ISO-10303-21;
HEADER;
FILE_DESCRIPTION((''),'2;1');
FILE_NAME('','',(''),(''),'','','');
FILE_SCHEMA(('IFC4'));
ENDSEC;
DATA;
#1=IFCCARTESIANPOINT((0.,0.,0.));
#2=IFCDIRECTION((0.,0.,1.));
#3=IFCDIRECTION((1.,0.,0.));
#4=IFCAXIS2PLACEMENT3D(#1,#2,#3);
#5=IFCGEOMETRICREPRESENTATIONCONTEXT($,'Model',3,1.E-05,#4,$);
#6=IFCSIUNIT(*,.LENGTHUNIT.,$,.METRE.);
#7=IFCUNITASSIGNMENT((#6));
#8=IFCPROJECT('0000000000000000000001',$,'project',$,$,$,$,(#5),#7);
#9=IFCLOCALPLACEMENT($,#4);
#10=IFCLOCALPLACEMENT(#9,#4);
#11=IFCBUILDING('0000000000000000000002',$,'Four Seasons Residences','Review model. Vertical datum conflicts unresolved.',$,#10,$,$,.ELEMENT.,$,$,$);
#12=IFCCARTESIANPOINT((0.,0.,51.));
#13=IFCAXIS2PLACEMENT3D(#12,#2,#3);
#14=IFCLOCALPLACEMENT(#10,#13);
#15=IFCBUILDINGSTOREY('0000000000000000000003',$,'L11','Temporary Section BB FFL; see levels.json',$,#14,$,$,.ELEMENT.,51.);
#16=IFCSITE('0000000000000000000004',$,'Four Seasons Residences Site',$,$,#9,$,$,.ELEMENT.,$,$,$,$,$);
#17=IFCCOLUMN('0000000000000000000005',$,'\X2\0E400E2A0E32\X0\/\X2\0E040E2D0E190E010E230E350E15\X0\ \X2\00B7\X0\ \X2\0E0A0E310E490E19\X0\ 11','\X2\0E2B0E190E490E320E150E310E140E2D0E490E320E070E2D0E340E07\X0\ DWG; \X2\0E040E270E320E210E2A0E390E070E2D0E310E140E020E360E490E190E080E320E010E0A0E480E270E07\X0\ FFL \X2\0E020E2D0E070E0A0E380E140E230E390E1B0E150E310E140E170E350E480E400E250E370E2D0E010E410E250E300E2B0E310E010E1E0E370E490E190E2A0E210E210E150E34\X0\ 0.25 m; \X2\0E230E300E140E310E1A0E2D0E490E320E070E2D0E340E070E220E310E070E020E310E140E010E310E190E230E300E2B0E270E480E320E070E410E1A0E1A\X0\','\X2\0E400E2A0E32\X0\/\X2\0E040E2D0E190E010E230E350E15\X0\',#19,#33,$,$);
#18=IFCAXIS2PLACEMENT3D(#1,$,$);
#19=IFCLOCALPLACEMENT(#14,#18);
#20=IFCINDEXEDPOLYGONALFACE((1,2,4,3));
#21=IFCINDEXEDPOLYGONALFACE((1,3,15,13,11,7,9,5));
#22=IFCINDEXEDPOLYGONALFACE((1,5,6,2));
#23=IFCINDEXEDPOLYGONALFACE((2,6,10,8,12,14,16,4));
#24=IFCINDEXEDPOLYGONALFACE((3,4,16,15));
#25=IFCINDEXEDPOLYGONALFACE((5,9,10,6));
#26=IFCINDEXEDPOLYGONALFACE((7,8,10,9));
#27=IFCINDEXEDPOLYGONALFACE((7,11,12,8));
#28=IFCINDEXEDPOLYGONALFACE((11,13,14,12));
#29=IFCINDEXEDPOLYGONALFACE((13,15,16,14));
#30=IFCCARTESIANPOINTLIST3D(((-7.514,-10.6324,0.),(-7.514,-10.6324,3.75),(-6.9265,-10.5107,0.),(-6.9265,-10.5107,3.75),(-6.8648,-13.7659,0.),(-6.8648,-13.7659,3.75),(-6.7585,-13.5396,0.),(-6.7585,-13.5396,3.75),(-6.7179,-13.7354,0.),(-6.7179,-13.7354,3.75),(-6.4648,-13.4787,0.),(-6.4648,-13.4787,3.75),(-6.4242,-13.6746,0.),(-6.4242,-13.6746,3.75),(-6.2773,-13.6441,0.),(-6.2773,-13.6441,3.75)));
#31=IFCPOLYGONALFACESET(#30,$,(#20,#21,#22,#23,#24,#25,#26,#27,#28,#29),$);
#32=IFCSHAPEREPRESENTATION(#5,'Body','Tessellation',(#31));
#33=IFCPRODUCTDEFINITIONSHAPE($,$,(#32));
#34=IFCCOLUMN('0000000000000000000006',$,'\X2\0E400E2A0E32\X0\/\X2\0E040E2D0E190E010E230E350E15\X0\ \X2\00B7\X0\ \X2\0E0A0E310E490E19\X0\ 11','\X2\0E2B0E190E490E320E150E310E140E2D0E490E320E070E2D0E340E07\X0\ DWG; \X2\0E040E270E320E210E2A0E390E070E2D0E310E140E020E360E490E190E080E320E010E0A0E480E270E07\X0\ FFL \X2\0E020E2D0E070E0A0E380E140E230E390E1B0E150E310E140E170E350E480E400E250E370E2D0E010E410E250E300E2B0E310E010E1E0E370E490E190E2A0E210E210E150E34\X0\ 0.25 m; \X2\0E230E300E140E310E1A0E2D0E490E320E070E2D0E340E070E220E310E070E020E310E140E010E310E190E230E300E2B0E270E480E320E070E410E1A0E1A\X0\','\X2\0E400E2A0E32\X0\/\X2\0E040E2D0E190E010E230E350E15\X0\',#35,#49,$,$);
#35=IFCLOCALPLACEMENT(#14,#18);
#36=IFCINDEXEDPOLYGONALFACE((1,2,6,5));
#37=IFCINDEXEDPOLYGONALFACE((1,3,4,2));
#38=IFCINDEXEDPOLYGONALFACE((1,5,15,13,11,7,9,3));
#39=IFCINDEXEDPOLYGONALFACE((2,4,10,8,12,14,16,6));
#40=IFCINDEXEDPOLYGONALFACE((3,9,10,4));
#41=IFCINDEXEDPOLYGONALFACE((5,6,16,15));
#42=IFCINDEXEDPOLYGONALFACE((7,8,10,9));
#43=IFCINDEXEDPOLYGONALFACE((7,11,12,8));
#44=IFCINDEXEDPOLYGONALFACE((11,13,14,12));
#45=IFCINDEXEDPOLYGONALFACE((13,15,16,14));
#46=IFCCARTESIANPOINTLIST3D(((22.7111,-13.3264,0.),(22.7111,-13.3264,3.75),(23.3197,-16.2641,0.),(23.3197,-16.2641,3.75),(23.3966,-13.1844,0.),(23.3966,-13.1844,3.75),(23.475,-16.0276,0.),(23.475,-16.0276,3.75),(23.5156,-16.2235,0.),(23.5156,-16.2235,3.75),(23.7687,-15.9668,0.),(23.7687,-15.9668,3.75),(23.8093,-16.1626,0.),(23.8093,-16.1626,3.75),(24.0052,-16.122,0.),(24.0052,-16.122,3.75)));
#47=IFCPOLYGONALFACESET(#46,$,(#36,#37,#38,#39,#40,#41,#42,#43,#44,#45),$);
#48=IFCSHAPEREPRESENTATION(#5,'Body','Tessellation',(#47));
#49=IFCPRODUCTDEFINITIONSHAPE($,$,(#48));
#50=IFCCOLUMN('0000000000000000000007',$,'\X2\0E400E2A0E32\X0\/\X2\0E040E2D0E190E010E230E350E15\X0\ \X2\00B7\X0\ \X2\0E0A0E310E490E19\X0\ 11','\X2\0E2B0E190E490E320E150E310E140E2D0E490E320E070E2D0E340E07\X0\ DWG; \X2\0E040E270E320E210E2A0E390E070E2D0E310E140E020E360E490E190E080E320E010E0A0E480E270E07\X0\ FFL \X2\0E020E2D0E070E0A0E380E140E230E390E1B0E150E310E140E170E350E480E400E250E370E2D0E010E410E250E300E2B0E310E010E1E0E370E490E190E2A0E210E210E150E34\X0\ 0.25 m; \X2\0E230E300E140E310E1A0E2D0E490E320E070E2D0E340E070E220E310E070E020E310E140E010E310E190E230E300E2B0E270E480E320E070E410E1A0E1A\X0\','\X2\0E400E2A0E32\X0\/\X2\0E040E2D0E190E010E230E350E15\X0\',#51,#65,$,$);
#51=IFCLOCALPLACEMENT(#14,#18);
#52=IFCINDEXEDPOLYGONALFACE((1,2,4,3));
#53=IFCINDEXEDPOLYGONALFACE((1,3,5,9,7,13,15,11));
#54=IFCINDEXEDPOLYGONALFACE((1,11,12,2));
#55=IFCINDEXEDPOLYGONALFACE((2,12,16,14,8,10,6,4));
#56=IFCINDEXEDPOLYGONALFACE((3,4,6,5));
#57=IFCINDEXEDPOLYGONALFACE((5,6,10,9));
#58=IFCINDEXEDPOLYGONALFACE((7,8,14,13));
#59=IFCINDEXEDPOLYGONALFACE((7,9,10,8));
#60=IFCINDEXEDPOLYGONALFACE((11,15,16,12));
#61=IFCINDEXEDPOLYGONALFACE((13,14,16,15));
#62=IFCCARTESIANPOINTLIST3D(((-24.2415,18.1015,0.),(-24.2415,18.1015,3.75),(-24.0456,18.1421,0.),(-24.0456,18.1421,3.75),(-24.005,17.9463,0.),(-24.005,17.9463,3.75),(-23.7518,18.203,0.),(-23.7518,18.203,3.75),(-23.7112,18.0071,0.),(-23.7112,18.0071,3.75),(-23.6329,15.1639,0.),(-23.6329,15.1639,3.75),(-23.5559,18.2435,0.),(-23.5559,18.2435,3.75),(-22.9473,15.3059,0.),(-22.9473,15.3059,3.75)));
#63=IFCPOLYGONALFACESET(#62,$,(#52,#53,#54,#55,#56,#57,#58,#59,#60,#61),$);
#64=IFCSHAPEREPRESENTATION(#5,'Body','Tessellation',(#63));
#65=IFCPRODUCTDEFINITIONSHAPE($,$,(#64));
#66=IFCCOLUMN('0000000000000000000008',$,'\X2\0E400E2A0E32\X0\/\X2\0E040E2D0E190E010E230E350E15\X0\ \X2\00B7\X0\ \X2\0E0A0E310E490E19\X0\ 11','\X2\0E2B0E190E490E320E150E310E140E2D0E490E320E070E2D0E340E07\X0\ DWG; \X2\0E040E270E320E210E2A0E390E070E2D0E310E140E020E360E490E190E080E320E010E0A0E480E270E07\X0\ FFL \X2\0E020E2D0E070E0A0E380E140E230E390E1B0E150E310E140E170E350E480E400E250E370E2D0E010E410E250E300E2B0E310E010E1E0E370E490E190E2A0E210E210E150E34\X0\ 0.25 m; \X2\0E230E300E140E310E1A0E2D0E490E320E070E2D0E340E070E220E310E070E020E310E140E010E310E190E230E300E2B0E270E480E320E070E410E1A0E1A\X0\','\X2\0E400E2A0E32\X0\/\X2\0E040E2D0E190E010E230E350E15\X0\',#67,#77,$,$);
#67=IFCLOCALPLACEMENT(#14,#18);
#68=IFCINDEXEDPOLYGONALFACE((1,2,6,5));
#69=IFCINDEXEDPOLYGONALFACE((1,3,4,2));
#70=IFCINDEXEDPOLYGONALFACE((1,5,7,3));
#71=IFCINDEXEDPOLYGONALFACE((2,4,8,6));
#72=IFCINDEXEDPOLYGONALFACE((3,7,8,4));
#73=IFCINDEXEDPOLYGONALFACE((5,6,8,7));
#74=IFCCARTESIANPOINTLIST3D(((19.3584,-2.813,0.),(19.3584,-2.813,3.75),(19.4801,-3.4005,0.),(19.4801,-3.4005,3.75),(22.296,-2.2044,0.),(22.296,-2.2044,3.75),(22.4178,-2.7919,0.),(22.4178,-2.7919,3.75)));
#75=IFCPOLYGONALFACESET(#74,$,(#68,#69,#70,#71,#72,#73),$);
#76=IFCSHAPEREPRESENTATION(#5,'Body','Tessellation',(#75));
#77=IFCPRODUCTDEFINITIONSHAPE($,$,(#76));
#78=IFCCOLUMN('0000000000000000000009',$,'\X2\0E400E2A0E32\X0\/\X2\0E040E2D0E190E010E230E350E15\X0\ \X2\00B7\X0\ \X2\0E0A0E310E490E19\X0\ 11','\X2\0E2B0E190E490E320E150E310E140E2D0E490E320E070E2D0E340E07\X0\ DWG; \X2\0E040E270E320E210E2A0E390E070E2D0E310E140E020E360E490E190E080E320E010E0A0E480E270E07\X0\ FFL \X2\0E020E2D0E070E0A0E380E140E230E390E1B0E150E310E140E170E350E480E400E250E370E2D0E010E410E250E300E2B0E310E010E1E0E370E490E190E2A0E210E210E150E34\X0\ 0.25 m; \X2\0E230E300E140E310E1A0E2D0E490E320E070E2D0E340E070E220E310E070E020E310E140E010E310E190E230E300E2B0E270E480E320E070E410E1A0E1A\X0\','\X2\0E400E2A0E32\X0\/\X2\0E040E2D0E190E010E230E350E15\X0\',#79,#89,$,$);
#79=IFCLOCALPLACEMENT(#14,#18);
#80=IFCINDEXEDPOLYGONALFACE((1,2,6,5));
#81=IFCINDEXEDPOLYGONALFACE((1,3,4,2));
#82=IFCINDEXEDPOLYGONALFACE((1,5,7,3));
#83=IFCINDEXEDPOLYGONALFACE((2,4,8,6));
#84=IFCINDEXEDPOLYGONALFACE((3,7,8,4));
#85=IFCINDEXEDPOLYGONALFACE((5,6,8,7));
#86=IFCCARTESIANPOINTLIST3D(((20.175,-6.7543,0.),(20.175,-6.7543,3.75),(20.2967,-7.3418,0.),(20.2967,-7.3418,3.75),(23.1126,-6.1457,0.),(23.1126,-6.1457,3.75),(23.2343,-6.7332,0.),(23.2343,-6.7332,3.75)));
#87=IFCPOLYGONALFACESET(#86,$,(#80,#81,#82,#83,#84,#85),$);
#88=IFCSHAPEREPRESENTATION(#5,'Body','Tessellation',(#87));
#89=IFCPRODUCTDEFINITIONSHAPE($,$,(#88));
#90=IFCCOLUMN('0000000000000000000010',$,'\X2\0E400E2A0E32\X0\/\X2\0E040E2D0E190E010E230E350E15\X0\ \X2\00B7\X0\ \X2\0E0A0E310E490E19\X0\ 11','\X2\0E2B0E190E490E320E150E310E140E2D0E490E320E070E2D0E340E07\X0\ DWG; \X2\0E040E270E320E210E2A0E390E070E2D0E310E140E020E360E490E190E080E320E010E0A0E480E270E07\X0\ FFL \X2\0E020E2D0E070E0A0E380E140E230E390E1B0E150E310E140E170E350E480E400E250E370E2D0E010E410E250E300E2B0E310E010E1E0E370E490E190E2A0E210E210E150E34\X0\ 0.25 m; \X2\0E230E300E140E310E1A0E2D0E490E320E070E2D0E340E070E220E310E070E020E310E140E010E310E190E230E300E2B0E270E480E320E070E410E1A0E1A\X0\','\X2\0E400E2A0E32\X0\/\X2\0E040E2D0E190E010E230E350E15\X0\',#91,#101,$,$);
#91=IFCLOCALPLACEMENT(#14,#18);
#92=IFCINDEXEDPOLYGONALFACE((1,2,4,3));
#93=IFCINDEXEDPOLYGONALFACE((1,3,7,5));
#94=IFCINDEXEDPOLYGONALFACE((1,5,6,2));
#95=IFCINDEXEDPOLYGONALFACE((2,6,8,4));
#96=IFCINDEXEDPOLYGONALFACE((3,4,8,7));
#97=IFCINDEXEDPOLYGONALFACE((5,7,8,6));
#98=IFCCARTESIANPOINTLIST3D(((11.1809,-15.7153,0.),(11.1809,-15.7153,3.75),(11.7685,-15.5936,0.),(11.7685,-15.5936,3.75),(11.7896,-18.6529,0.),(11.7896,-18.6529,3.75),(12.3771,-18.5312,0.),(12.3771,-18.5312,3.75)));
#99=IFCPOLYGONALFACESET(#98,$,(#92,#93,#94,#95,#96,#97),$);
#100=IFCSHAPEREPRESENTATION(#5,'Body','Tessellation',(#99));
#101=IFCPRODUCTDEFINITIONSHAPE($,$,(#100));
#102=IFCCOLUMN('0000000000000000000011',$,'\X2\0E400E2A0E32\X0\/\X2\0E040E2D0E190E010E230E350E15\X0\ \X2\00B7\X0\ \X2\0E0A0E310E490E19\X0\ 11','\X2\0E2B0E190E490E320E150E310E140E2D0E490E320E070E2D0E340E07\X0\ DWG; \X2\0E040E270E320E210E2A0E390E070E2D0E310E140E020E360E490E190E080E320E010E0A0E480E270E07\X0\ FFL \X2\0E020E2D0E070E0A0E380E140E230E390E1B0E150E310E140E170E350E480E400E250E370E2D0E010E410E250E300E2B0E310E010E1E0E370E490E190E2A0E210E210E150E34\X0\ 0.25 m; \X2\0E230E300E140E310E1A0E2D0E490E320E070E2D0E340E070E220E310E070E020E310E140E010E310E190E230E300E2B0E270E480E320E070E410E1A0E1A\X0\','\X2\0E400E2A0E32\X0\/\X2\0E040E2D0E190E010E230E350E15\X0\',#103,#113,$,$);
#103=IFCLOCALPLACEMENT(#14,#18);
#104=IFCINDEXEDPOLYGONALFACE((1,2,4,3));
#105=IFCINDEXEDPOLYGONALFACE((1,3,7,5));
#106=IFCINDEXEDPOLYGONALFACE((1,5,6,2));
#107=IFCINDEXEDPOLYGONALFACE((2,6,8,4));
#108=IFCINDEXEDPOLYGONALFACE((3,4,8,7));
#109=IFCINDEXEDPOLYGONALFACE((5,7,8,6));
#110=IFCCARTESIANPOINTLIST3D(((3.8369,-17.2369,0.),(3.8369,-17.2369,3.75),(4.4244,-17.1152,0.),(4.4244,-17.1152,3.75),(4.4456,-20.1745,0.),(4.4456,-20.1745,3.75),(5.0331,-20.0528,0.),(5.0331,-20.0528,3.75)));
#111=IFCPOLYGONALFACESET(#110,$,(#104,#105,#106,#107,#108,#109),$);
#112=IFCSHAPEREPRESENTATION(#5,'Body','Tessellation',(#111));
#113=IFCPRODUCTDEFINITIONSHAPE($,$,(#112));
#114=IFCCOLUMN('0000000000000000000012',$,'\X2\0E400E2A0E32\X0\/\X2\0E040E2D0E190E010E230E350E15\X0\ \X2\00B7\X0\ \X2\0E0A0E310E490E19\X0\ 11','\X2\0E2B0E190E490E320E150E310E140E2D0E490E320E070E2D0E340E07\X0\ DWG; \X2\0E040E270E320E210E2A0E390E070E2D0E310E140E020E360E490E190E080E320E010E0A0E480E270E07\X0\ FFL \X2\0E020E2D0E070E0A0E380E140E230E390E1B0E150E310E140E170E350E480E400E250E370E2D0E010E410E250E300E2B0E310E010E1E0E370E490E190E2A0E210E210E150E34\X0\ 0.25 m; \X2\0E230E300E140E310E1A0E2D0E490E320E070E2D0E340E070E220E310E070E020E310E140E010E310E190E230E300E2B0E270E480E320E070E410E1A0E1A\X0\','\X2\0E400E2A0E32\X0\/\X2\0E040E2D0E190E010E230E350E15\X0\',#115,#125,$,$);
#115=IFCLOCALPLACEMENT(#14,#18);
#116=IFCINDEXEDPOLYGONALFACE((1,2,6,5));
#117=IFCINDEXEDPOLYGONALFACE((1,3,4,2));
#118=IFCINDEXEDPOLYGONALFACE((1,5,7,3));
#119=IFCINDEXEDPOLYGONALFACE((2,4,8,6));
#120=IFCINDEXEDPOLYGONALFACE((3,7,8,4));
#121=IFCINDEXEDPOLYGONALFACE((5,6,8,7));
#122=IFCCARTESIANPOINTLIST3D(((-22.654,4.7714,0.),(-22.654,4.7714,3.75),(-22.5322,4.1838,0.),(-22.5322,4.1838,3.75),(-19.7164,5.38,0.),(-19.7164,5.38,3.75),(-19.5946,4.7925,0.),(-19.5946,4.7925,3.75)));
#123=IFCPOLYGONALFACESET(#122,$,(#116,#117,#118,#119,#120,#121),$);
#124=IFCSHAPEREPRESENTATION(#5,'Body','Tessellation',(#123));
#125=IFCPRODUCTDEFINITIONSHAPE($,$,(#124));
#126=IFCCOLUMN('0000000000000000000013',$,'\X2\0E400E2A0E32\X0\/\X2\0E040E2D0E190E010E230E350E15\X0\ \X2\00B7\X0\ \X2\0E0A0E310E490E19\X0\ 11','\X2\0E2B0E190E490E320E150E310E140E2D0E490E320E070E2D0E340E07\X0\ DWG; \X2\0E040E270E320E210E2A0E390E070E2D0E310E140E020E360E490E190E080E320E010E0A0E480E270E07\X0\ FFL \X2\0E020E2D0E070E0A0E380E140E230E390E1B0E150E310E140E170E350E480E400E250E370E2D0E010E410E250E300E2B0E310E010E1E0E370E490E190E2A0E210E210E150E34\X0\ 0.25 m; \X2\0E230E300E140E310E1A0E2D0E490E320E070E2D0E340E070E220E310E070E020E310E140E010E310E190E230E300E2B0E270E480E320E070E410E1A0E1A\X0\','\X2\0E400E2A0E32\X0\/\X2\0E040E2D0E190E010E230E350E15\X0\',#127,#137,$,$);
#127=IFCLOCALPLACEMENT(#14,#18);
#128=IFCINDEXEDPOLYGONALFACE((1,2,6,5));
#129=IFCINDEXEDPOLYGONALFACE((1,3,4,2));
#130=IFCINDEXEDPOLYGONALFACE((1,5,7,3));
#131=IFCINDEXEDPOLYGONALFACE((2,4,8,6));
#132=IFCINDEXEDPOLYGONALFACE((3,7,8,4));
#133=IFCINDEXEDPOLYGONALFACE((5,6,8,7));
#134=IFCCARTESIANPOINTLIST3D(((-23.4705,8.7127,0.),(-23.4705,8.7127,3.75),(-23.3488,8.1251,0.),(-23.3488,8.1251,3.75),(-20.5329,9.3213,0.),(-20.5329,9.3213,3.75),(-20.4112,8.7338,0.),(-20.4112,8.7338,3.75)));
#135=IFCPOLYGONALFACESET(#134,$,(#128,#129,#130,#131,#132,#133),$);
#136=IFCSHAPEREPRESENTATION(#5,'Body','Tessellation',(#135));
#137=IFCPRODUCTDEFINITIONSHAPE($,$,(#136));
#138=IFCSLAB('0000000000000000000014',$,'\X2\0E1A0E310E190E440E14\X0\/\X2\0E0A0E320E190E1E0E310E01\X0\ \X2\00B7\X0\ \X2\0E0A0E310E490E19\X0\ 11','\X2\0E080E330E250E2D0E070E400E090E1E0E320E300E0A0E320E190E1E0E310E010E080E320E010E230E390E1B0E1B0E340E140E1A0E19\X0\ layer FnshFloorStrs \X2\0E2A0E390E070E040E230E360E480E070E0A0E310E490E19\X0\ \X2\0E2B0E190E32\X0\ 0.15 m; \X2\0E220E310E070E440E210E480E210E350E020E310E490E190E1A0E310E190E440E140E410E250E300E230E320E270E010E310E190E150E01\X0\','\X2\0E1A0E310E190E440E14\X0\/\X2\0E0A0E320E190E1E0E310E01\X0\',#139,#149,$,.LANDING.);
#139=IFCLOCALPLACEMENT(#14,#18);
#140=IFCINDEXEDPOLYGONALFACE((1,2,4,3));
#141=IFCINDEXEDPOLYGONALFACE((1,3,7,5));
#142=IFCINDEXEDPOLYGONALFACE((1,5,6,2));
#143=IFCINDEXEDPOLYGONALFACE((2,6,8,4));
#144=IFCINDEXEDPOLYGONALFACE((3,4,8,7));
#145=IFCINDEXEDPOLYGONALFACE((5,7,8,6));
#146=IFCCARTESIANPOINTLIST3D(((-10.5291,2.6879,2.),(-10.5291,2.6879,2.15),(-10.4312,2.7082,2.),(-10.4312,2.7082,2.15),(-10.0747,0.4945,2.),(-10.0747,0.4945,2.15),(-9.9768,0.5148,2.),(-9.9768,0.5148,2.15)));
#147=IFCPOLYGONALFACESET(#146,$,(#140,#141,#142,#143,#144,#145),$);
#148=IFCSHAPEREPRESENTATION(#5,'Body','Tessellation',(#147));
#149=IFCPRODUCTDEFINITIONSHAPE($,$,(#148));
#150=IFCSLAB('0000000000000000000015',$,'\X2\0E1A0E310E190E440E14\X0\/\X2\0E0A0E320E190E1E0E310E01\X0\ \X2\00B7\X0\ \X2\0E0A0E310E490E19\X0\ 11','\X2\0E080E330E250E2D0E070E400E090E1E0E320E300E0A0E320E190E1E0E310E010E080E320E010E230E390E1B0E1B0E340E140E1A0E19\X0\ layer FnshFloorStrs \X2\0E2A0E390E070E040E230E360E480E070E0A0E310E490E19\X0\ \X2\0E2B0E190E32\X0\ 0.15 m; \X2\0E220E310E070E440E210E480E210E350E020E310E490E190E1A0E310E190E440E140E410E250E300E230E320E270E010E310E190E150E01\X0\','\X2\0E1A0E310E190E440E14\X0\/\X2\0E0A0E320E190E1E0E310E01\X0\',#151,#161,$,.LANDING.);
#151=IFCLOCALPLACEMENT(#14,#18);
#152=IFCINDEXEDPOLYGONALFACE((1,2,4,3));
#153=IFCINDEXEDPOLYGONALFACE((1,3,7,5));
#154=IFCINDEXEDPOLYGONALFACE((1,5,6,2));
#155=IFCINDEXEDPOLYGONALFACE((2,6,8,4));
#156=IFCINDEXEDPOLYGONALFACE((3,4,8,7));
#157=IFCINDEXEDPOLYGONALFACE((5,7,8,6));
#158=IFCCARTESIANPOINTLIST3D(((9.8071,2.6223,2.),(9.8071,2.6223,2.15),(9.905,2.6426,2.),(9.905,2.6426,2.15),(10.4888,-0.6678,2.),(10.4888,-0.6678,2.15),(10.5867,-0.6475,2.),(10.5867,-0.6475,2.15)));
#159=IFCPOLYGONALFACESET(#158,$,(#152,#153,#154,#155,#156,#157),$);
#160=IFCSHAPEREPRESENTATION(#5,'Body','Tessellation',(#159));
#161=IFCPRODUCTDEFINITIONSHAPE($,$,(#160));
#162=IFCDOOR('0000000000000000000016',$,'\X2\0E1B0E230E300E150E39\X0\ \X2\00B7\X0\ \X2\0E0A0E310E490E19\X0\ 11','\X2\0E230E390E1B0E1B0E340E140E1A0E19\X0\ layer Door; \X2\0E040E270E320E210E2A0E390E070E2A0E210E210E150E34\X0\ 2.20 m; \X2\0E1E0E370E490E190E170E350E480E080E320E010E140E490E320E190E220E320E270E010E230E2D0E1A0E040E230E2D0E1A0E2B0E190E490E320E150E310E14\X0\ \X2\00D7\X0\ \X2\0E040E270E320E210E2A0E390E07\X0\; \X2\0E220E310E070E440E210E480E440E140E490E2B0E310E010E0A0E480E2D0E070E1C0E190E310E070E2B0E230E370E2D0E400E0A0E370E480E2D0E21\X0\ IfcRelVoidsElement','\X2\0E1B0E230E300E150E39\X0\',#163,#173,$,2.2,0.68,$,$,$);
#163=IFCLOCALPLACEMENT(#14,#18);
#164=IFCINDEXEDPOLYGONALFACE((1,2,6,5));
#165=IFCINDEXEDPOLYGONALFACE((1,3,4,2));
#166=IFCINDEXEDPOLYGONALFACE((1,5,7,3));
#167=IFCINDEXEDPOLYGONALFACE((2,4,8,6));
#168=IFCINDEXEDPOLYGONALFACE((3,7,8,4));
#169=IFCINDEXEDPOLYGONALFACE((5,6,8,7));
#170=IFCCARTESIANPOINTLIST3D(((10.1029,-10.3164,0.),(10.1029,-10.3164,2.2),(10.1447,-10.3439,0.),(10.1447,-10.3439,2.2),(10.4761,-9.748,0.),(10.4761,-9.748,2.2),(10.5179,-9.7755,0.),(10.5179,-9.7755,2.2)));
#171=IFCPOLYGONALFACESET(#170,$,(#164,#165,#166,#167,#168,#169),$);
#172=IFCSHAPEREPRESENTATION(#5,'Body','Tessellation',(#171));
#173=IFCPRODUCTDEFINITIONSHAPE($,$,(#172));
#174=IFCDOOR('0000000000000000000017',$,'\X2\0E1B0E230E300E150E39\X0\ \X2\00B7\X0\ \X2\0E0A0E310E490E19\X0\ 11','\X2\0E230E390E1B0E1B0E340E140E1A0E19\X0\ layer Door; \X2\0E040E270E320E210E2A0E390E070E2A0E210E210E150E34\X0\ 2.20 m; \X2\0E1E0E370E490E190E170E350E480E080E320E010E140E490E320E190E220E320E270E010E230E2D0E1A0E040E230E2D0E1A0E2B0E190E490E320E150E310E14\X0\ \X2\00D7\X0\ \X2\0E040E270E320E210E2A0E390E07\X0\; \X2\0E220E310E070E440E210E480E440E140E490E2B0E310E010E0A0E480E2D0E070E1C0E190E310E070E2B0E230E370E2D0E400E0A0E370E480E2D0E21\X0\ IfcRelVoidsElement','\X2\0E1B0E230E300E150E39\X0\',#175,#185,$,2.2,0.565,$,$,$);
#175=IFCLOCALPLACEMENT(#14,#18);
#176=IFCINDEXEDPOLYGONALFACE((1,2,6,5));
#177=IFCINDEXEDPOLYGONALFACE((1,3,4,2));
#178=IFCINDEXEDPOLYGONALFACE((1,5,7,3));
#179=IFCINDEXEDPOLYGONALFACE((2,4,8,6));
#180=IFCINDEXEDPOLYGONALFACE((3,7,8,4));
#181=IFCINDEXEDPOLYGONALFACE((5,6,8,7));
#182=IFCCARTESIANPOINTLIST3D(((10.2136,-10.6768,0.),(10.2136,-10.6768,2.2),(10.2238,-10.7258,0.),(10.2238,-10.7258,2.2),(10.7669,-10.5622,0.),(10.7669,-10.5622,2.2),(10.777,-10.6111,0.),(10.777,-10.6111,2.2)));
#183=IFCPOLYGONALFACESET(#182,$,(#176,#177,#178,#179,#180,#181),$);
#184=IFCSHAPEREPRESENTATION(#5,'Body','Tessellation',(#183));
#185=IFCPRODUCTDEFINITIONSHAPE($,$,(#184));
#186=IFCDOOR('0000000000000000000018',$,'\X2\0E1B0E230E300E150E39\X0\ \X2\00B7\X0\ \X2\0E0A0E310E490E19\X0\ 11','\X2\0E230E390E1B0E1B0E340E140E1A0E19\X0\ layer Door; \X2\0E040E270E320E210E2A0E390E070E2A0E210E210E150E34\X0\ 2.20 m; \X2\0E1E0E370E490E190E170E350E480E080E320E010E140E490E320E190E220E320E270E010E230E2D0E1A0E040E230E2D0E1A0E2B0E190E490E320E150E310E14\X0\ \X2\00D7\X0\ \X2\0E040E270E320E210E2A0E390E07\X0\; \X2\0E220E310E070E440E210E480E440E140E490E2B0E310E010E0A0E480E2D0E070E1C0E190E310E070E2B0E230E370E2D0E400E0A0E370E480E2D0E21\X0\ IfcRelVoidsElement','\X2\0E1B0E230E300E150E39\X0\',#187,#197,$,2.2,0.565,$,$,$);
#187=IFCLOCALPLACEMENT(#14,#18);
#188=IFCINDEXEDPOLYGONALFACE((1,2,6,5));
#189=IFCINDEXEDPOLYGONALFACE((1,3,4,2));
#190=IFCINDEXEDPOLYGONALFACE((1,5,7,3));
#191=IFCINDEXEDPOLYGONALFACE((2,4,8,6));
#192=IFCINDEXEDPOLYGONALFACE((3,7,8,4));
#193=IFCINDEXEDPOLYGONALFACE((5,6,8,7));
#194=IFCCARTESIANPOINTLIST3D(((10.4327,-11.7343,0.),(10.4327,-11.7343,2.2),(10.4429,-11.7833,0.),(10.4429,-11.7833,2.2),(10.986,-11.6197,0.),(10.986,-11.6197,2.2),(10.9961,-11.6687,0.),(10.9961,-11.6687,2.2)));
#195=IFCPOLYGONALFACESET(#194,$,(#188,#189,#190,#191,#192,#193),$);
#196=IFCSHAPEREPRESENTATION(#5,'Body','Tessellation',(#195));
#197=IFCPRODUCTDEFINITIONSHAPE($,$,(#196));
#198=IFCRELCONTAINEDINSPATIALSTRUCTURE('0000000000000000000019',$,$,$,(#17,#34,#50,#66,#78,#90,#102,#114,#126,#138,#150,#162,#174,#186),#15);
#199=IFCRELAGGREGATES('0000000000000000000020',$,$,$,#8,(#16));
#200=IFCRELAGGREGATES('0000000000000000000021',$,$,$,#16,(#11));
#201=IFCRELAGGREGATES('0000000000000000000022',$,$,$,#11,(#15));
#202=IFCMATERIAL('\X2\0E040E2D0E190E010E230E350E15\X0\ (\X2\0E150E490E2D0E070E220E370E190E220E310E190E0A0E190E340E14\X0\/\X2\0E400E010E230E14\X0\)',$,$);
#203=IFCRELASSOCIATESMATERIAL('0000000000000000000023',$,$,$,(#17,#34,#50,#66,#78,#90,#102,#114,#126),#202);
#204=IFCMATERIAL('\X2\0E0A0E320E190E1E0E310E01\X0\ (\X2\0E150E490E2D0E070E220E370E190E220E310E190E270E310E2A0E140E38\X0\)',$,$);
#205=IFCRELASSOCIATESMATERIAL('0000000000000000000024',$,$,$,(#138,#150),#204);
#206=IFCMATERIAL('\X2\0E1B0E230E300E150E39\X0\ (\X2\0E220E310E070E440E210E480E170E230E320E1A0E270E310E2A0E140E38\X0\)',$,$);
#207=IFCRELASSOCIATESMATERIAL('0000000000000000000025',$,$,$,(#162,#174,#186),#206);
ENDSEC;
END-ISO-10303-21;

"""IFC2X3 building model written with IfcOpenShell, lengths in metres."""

from ifc_helpers import new_model, si_unit, frame, origin_with_axes, place, context, project, spatial, polyline, outline, extrude, material, element, save


model = new_model("IFC2X3")

# Units and contexts
model_context = context("Model", 3, precision=1e-05, world=origin_with_axes())
ifc_project = project(units=[si_unit("LENGTHUNIT", "METRE")], contexts=[model_context])

# Site, building, storey
site_placement = place(None, origin_with_axes())
site = spatial("IfcSite", under=ifc_project, at=site_placement, Name="Four Seasons Residences Site", CompositionType="ELEMENT")
building_placement = place(site_placement, origin_with_axes())
building = spatial("IfcBuilding", under=site, at=building_placement, Name="Four Seasons Residences", Description="Review model. Vertical datum conflicts unresolved.", CompositionType="ELEMENT")
storey_placement = place(building_placement, frame((0.0, 0.0, 51.0), z_axis=(0.0, 0.0, 1.0), x_axis=(1.0, 0.0, 0.0)))
storey = spatial("IfcBuildingStorey", under=building, at=storey_placement, Name="L11", Description="Temporary Section BB FFL; see levels.json", CompositionType="ELEMENT", Elevation=51.0)

# Columns
ifc_material_1 = material(Name="คอนกรีต (ต้องยืนยันชนิด/เกรด)")
column_1_placement = place(storey_placement, origin_with_axes())
element("IfcColumn", 1, at=column_1_placement, inside=storey, material=ifc_material_1, Name="เสา/คอนกรีต · ชั้น 11", Description="หน้าตัดอ้างอิง DWG; ความสูงอัดขึ้นจากช่วง FFL ของชุดรูปตัดที่เลือกและหักพื้นสมมติ 0.25 m; ระดับอ้างอิงยังขัดกันระหว่างแบบ", ObjectType="เสา/คอนกรีต", context=model_context, shape_type="SweptSolid", body=[
    extrude(outline(polyline([(-6.2773, -13.6441), (-6.9265, -10.5107), (-7.514, -10.6324), (-6.8648, -13.7659), (-6.7179, -13.7354), (-6.7585, -13.5396), (-6.4648, -13.4787), (-6.4242, -13.6746), (-6.2773, -13.6441)])), origin_with_axes(), (0.0, 0.0, 1.0), 3.75),
])
column_2_placement = place(storey_placement, origin_with_axes())
element("IfcColumn", 2, at=column_2_placement, inside=storey, material=ifc_material_1, Name="เสา/คอนกรีต · ชั้น 11", Description="หน้าตัดอ้างอิง DWG; ความสูงอัดขึ้นจากช่วง FFL ของชุดรูปตัดที่เลือกและหักพื้นสมมติ 0.25 m; ระดับอ้างอิงยังขัดกันระหว่างแบบ", ObjectType="เสา/คอนกรีต", context=model_context, shape_type="SweptSolid", body=[
    extrude(outline(polyline([(24.0052, -16.122), (23.3966, -13.1844), (22.7111, -13.3264), (23.3197, -16.2641), (23.5156, -16.2235), (23.475, -16.0276), (23.7687, -15.9668), (23.8093, -16.1626), (24.0052, -16.122)])), origin_with_axes(), (0.0, 0.0, 1.0), 3.75),
])
column_3_placement = place(storey_placement, origin_with_axes())
element("IfcColumn", 3, at=column_3_placement, inside=storey, material=ifc_material_1, Name="เสา/คอนกรีต · ชั้น 11", Description="หน้าตัดอ้างอิง DWG; ความสูงอัดขึ้นจากช่วง FFL ของชุดรูปตัดที่เลือกและหักพื้นสมมติ 0.25 m; ระดับอ้างอิงยังขัดกันระหว่างแบบ", ObjectType="เสา/คอนกรีต", context=model_context, shape_type="SweptSolid", body=[
    extrude(outline(polyline([(-23.5559, 18.2435), (-23.7518, 18.203), (-23.7112, 18.0071), (-24.005, 17.9463), (-24.0456, 18.1421), (-24.2415, 18.1015), (-23.6329, 15.1639), (-22.9473, 15.3059), (-23.5559, 18.2435)])), origin_with_axes(), (0.0, 0.0, 1.0), 3.75),
])
column_4_placement = place(storey_placement, origin_with_axes())
element("IfcColumn", 4, at=column_4_placement, inside=storey, material=ifc_material_1, Name="เสา/คอนกรีต · ชั้น 11", Description="หน้าตัดอ้างอิง DWG; ความสูงอัดขึ้นจากช่วง FFL ของชุดรูปตัดที่เลือกและหักพื้นสมมติ 0.25 m; ระดับอ้างอิงยังขัดกันระหว่างแบบ", ObjectType="เสา/คอนกรีต", context=model_context, shape_type="SweptSolid", body=[
    extrude(outline(polyline([(22.296, -2.2044), (22.4178, -2.7919), (19.4801, -3.4005), (19.3584, -2.813), (22.296, -2.2044)])), origin_with_axes(), (0.0, 0.0, 1.0), 3.75),
])
column_5_placement = place(storey_placement, origin_with_axes())
element("IfcColumn", 5, at=column_5_placement, inside=storey, material=ifc_material_1, Name="เสา/คอนกรีต · ชั้น 11", Description="หน้าตัดอ้างอิง DWG; ความสูงอัดขึ้นจากช่วง FFL ของชุดรูปตัดที่เลือกและหักพื้นสมมติ 0.25 m; ระดับอ้างอิงยังขัดกันระหว่างแบบ", ObjectType="เสา/คอนกรีต", context=model_context, shape_type="SweptSolid", body=[
    extrude(outline(polyline([(23.1126, -6.1457), (23.2343, -6.7332), (20.2967, -7.3418), (20.175, -6.7543), (23.1126, -6.1457)])), origin_with_axes(), (0.0, 0.0, 1.0), 3.75),
])
column_6_placement = place(storey_placement, origin_with_axes())
element("IfcColumn", 6, at=column_6_placement, inside=storey, material=ifc_material_1, Name="เสา/คอนกรีต · ชั้น 11", Description="หน้าตัดอ้างอิง DWG; ความสูงอัดขึ้นจากช่วง FFL ของชุดรูปตัดที่เลือกและหักพื้นสมมติ 0.25 m; ระดับอ้างอิงยังขัดกันระหว่างแบบ", ObjectType="เสา/คอนกรีต", context=model_context, shape_type="SweptSolid", body=[
    extrude(outline(polyline([(11.7685, -15.5936), (12.3771, -18.5312), (11.7896, -18.6529), (11.1809, -15.7153), (11.7685, -15.5936)])), origin_with_axes(), (0.0, 0.0, 1.0), 3.75),
])
column_7_placement = place(storey_placement, origin_with_axes())
element("IfcColumn", 7, at=column_7_placement, inside=storey, material=ifc_material_1, Name="เสา/คอนกรีต · ชั้น 11", Description="หน้าตัดอ้างอิง DWG; ความสูงอัดขึ้นจากช่วง FFL ของชุดรูปตัดที่เลือกและหักพื้นสมมติ 0.25 m; ระดับอ้างอิงยังขัดกันระหว่างแบบ", ObjectType="เสา/คอนกรีต", context=model_context, shape_type="SweptSolid", body=[
    extrude(outline(polyline([(4.4244, -17.1152), (5.0331, -20.0528), (4.4456, -20.1745), (3.8369, -17.2369), (4.4244, -17.1152)])), origin_with_axes(), (0.0, 0.0, 1.0), 3.75),
])
column_8_placement = place(storey_placement, origin_with_axes())
element("IfcColumn", 8, at=column_8_placement, inside=storey, material=ifc_material_1, Name="เสา/คอนกรีต · ชั้น 11", Description="หน้าตัดอ้างอิง DWG; ความสูงอัดขึ้นจากช่วง FFL ของชุดรูปตัดที่เลือกและหักพื้นสมมติ 0.25 m; ระดับอ้างอิงยังขัดกันระหว่างแบบ", ObjectType="เสา/คอนกรีต", context=model_context, shape_type="SweptSolid", body=[
    extrude(outline(polyline([(-19.7164, 5.38), (-19.5946, 4.7925), (-22.5322, 4.1838), (-22.654, 4.7714), (-19.7164, 5.38)])), origin_with_axes(), (0.0, 0.0, 1.0), 3.75),
])
column_9_placement = place(storey_placement, origin_with_axes())
element("IfcColumn", 9, at=column_9_placement, inside=storey, material=ifc_material_1, Name="เสา/คอนกรีต · ชั้น 11", Description="หน้าตัดอ้างอิง DWG; ความสูงอัดขึ้นจากช่วง FFL ของชุดรูปตัดที่เลือกและหักพื้นสมมติ 0.25 m; ระดับอ้างอิงยังขัดกันระหว่างแบบ", ObjectType="เสา/คอนกรีต", context=model_context, shape_type="SweptSolid", body=[
    extrude(outline(polyline([(-20.5329, 9.3213), (-20.4112, 8.7338), (-23.3488, 8.1251), (-23.4705, 8.7127), (-20.5329, 9.3213)])), origin_with_axes(), (0.0, 0.0, 1.0), 3.75),
])

# Slabs
ifc_material_2 = material(Name="ชานพัก (ต้องยืนยันวัสดุ)")
slab_1_placement = place(storey_placement, origin_with_axes())
element("IfcSlab", 10, at=slab_1_placement, inside=storey, material=ifc_material_2, Name="บันได/ชานพัก · ชั้น 11", Description="จำลองเฉพาะชานพักจากรูปปิดบน layer FnshFloorStrs สูงครึ่งชั้น หนา 0.15 m; ยังไม่มีขั้นบันไดและราวกันตก", ObjectType="บันได/ชานพัก", PredefinedType="LANDING", context=model_context, shape_type="SweptSolid", body=[
    extrude(outline(polyline([(-10.5291, 2.6879), (-10.0747, 0.4945), (-9.9768, 0.5148), (-10.4312, 2.7082), (-10.5291, 2.6879)])), frame((0.0, 0.0, 2.0), z_axis=(0.0, 0.0, 1.0), x_axis=(1.0, 0.0, 0.0)), (0.0, 0.0, 1.0), 0.15),
])
slab_2_placement = place(storey_placement, origin_with_axes())
element("IfcSlab", 11, at=slab_2_placement, inside=storey, material=ifc_material_2, Name="บันได/ชานพัก · ชั้น 11", Description="จำลองเฉพาะชานพักจากรูปปิดบน layer FnshFloorStrs สูงครึ่งชั้น หนา 0.15 m; ยังไม่มีขั้นบันไดและราวกันตก", ObjectType="บันได/ชานพัก", PredefinedType="LANDING", context=model_context, shape_type="SweptSolid", body=[
    extrude(outline(polyline([(10.5867, -0.6475), (10.4888, -0.6678), (9.8071, 2.6223), (9.905, 2.6426), (10.5867, -0.6475)])), frame((0.0, 0.0, 2.0), z_axis=(0.0, 0.0, 1.0), x_axis=(1.0, 0.0, 0.0)), (0.0, 0.0, 1.0), 0.15),
])

# Doors
ifc_material_3 = material(Name="ประตู (ยังไม่ทราบวัสดุ)")
door_1_placement = place(storey_placement, origin_with_axes())
element("IfcDoor", 12, at=door_1_placement, inside=storey, material=ifc_material_3, Name="ประตู · ชั้น 11", Description="รูปปิดบน layer Door; ความสูงสมมติ 2.20 m; พื้นที่จากด้านยาวกรอบครอบหน้าตัด × ความสูง; ยังไม่ได้หักช่องผนังหรือเชื่อม IfcRelVoidsElement", ObjectType="ประตู", OverallHeight=2.2, OverallWidth=0.68, context=model_context, shape_type="SweptSolid", body=[
    extrude(outline(polyline([(10.5179, -9.7755), (10.1447, -10.3439), (10.1029, -10.3164), (10.4761, -9.748), (10.5179, -9.7755)])), origin_with_axes(), (0.0, 0.0, 1.0), 2.2),
])
door_2_placement = place(storey_placement, origin_with_axes())
element("IfcDoor", 13, at=door_2_placement, inside=storey, material=ifc_material_3, Name="ประตู · ชั้น 11", Description="รูปปิดบน layer Door; ความสูงสมมติ 2.20 m; พื้นที่จากด้านยาวกรอบครอบหน้าตัด × ความสูง; ยังไม่ได้หักช่องผนังหรือเชื่อม IfcRelVoidsElement", ObjectType="ประตู", OverallHeight=2.2, OverallWidth=0.565, context=model_context, shape_type="SweptSolid", body=[
    extrude(outline(polyline([(10.7669, -10.5622), (10.2136, -10.6768), (10.2238, -10.7258), (10.777, -10.6111), (10.7669, -10.5622)])), origin_with_axes(), (0.0, 0.0, 1.0), 2.2),
])
door_3_placement = place(storey_placement, origin_with_axes())
element("IfcDoor", 14, at=door_3_placement, inside=storey, material=ifc_material_3, Name="ประตู · ชั้น 11", Description="รูปปิดบน layer Door; ความสูงสมมติ 2.20 m; พื้นที่จากด้านยาวกรอบครอบหน้าตัด × ความสูง; ยังไม่ได้หักช่องผนังหรือเชื่อม IfcRelVoidsElement", ObjectType="ประตู", OverallHeight=2.2, OverallWidth=0.565, context=model_context, shape_type="SweptSolid", body=[
    extrude(outline(polyline([(10.9961, -11.6687), (10.4429, -11.7833), (10.4327, -11.7343), (10.986, -11.6197), (10.9961, -11.6687)])), origin_with_axes(), (0.0, 0.0, 1.0), 2.2),
])

save(model, "model.ifc")
